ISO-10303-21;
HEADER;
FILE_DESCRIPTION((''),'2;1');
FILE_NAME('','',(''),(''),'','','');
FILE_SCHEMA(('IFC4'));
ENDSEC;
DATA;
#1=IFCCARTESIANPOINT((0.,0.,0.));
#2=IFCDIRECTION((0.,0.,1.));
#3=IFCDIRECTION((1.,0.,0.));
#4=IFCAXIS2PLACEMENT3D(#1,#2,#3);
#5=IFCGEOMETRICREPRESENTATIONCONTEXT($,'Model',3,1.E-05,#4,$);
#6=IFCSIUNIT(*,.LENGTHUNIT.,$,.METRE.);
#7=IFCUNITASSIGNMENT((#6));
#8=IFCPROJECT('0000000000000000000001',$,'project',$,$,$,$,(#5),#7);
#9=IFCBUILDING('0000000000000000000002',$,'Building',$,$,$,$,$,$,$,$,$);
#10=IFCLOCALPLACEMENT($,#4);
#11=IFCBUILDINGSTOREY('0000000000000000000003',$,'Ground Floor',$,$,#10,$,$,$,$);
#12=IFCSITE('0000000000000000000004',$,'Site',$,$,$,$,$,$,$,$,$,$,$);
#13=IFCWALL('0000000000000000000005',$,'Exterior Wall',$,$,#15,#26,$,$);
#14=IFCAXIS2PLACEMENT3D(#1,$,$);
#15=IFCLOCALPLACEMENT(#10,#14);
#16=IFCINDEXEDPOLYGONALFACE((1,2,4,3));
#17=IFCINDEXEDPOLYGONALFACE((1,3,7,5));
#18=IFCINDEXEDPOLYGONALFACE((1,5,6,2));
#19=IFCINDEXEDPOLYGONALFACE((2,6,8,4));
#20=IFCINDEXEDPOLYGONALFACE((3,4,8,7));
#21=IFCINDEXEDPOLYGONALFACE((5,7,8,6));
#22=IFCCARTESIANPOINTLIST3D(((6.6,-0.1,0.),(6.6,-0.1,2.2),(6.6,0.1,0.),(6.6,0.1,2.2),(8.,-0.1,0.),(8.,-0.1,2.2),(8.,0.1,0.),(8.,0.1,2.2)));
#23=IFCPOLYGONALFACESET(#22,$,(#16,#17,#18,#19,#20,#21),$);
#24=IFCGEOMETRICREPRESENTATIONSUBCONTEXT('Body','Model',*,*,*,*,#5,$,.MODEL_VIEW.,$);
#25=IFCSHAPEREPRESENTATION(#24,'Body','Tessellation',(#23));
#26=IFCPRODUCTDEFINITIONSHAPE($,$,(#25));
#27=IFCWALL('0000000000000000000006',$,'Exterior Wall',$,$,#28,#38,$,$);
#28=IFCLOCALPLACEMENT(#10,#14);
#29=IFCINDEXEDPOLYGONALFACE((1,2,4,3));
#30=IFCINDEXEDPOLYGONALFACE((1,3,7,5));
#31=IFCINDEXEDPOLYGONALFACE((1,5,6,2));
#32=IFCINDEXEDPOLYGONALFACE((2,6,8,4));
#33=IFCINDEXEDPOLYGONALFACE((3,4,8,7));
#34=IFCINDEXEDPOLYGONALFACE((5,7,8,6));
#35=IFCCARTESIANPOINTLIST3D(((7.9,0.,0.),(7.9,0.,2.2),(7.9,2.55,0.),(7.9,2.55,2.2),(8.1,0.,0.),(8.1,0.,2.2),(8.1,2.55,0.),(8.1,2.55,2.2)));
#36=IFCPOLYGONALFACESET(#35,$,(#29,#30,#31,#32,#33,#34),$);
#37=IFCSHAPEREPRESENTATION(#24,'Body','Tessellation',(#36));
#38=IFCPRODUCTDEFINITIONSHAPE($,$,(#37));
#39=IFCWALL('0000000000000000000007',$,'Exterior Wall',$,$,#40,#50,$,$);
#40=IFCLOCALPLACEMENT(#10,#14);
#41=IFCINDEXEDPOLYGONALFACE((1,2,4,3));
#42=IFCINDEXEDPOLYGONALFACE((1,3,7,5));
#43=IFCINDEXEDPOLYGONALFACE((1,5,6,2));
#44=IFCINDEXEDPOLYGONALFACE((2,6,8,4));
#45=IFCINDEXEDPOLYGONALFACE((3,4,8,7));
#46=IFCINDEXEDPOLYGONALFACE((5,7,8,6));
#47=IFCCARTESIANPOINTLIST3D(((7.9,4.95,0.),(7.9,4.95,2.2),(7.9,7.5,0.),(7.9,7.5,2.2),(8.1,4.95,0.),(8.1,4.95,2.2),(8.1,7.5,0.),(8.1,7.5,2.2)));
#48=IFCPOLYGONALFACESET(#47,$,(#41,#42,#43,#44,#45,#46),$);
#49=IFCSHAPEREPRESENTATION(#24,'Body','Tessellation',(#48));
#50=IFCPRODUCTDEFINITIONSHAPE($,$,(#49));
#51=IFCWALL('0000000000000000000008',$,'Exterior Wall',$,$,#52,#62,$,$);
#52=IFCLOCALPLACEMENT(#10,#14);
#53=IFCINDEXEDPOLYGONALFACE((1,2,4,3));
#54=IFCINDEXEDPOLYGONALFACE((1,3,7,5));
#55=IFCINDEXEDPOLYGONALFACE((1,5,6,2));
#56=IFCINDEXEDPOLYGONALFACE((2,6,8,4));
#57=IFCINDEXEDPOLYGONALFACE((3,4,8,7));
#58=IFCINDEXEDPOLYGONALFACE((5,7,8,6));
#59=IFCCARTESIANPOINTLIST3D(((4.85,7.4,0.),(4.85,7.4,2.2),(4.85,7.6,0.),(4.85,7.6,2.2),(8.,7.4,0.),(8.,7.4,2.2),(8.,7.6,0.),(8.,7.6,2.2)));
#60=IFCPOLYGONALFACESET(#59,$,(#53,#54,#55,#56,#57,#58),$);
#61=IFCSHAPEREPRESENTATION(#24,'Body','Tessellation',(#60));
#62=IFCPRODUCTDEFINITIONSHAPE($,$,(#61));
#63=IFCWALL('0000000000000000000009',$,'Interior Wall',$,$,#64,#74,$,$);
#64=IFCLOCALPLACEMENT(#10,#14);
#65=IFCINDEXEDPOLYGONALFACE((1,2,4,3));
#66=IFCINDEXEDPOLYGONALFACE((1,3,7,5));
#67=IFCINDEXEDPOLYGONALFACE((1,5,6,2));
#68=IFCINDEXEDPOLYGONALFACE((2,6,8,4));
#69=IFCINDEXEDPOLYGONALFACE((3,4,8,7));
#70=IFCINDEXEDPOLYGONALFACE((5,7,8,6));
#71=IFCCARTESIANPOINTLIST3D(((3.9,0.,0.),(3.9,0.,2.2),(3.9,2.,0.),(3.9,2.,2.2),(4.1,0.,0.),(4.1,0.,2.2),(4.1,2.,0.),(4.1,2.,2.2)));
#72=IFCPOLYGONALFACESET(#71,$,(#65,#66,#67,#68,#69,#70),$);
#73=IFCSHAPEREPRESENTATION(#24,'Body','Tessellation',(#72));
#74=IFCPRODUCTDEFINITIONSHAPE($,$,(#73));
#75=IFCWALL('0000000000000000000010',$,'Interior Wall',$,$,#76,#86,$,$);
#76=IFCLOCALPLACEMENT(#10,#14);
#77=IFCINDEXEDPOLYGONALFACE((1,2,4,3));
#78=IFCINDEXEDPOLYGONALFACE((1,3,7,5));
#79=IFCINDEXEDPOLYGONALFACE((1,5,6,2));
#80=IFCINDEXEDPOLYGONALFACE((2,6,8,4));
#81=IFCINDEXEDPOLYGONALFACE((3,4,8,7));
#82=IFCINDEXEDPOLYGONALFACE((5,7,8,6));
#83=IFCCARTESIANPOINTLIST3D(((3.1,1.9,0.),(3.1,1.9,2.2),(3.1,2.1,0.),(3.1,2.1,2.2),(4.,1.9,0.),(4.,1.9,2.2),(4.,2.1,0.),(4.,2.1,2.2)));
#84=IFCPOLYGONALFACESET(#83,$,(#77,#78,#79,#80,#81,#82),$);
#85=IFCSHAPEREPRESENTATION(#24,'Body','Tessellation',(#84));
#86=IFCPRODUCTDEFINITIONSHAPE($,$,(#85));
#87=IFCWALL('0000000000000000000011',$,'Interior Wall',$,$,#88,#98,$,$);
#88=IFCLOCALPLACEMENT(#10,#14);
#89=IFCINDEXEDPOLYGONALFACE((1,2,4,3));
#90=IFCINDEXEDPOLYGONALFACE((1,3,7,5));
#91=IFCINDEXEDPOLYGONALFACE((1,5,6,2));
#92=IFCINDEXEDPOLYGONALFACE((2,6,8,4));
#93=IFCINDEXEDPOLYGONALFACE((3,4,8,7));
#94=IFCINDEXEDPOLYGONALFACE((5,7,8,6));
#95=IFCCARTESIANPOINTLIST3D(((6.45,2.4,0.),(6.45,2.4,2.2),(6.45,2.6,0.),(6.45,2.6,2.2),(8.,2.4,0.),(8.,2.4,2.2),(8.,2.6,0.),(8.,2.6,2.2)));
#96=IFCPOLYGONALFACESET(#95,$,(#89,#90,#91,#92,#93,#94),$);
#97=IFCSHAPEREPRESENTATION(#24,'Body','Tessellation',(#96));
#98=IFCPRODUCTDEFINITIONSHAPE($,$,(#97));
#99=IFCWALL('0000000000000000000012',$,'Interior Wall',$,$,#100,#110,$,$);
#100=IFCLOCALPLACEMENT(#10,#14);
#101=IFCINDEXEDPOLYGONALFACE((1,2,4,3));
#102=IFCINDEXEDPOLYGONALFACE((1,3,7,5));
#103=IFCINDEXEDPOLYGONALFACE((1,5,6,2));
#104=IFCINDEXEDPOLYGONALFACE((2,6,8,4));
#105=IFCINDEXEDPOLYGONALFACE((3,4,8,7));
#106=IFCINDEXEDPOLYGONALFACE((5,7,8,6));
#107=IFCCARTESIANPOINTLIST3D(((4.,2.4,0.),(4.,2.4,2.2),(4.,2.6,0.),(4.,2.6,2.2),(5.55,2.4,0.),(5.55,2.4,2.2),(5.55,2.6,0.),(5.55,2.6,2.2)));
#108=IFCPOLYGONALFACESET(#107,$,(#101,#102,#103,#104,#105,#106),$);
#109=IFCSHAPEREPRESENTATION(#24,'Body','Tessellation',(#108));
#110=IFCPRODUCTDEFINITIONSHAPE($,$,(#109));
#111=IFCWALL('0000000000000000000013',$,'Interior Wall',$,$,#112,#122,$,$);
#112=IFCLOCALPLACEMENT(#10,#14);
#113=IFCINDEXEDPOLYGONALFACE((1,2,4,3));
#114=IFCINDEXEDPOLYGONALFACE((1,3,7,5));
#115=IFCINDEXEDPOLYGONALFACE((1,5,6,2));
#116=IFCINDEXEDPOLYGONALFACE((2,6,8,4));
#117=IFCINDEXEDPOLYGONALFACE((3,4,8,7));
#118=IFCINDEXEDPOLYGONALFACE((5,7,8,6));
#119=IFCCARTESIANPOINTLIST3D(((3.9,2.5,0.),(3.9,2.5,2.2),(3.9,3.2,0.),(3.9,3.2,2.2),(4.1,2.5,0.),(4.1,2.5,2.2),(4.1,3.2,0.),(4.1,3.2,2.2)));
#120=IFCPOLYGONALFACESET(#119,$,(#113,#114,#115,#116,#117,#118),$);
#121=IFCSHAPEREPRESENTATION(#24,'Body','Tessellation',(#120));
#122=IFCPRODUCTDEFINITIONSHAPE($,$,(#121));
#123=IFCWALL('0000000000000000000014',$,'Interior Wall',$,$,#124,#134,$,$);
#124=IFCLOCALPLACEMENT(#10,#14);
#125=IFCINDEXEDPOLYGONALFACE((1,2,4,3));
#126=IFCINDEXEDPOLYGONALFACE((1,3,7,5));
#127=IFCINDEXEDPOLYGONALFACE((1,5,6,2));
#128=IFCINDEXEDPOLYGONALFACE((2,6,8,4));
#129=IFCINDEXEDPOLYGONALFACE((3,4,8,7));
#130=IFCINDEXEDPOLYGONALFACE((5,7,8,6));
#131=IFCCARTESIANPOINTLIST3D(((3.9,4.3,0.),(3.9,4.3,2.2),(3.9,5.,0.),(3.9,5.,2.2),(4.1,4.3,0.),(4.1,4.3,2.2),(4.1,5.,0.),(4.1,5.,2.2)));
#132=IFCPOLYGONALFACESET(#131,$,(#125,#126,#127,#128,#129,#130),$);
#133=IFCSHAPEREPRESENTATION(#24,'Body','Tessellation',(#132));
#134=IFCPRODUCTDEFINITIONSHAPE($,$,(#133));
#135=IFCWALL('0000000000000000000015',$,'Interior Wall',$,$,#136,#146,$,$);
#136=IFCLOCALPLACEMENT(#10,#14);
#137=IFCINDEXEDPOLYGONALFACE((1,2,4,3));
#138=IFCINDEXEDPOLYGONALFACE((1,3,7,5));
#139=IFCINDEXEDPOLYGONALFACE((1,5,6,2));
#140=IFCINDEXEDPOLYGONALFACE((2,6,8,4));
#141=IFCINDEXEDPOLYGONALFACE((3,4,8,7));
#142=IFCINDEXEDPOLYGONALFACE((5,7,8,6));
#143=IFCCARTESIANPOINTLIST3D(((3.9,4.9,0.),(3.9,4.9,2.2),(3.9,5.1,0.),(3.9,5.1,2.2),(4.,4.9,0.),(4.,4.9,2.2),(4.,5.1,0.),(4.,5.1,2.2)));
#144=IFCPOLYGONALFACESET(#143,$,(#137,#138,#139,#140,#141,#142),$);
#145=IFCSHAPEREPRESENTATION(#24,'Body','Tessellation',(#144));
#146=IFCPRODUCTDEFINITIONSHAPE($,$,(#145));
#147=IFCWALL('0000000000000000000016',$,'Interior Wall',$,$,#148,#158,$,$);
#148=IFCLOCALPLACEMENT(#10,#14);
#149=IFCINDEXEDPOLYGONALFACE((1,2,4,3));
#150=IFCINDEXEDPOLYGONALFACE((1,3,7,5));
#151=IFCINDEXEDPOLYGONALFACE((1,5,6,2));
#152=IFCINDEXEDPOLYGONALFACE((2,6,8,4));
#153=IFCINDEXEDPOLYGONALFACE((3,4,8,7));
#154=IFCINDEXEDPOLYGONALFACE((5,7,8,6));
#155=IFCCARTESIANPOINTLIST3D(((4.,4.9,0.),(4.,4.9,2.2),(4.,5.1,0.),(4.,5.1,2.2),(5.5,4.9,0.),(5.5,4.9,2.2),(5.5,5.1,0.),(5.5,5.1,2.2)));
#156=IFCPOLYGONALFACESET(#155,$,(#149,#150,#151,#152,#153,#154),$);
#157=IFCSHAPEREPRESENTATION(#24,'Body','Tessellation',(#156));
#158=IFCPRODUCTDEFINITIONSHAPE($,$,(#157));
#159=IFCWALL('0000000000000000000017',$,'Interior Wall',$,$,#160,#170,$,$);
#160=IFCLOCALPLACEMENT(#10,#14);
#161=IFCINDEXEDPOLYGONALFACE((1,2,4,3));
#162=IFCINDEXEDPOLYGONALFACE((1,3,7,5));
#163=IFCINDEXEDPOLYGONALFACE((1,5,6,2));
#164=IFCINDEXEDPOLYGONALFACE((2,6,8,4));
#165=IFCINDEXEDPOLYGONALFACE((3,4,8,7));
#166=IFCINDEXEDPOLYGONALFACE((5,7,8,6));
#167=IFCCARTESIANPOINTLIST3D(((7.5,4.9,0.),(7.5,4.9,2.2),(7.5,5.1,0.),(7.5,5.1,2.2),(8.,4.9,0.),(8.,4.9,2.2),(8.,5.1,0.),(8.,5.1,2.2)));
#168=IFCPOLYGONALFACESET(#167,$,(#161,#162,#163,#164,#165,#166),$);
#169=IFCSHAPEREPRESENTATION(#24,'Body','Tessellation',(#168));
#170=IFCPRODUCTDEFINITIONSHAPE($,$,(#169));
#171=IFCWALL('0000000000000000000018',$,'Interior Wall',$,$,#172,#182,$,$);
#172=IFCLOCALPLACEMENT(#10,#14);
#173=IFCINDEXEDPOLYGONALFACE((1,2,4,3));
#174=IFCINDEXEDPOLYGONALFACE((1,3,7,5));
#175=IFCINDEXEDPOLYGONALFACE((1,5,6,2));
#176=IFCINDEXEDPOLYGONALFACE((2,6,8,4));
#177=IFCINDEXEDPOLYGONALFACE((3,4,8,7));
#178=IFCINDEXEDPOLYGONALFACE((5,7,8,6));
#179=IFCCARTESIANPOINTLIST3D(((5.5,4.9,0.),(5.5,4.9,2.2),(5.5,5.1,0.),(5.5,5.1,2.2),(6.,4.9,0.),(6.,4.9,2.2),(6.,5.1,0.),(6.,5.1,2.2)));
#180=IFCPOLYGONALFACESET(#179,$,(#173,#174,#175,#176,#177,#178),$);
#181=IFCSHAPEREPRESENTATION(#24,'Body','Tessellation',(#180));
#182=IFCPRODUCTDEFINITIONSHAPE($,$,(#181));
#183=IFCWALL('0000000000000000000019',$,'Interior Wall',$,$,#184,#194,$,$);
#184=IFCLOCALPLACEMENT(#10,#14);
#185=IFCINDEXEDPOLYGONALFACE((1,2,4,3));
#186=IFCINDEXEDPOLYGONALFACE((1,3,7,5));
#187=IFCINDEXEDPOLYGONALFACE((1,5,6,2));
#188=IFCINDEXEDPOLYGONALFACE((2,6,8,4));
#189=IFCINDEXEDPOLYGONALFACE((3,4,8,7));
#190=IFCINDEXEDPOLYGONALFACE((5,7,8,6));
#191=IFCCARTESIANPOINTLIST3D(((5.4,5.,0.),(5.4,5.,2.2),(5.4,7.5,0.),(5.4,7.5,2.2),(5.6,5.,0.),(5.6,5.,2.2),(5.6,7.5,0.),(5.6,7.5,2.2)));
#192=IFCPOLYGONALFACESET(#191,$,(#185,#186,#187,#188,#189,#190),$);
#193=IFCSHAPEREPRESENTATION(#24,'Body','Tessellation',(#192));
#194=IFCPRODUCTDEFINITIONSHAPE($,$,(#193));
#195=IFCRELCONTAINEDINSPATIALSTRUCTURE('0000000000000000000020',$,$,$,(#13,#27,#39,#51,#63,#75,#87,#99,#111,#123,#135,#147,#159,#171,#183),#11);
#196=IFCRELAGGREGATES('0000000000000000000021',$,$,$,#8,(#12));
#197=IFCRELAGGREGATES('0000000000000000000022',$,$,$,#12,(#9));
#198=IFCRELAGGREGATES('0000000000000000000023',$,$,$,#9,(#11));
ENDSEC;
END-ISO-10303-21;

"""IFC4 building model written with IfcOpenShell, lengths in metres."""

from ifc_helpers import new_model, si_unit, frame, origin_with_axes, place, context, subcontext, project, spatial, indexed_curve, outline, extrude, element, save


model = new_model("IFC4")

# Units and contexts
model_context = context("Model", 3, precision=1e-05, world=origin_with_axes())
body_context = subcontext(model_context, "Body", "Model", "MODEL_VIEW")
ifc_project = project(units=[si_unit("LENGTHUNIT", "METRE")], contexts=[model_context])

# Site, building, storey
site = spatial("IfcSite", under=ifc_project, Name="Site")
building = spatial("IfcBuilding", under=site, Name="Building")
storey_placement = place(None, origin_with_axes())
storey = spatial("IfcBuildingStorey", under=building, at=storey_placement, Name="Ground Floor")

# Walls
wall_1_placement = place(storey_placement, frame((6.6, 0.0, 0.0), z_axis=(0.0, 0.0, 1.0), x_axis=(1.0, 0.0, 0.0)))
element("IfcWall", 1, at=wall_1_placement, inside=storey, Name="Exterior Wall", context=body_context, shape_type="SweptSolid", body=[
    extrude(outline(indexed_curve([(0.0, 0.0), (0.0, 0.2), (1.4, 0.2), (1.4, 0.0), (0.0, 0.0)], self_intersect=False)), frame((0.0, -0.1, 0.0), z_axis=(0.0, 0.0, 1.0), x_axis=(1.0, 0.0, 0.0)), (0.0, 0.0, 1.0), 2.2),
])
for number, where, z_axis, x_axis, name in (
    (2, (8.0, 0.0, 0.0), (0.0, 0.0, 1.0), (0.0, 1.0, 0.0), "Exterior Wall"),
    (3, (8.0, 4.95, 0.0), (0.0, 0.0, 1.0), (0.0, 1.0, 0.0), "Exterior Wall"),
):
    element("IfcWall", number, at=place(storey_placement, frame(where, z_axis=z_axis, x_axis=x_axis)), inside=storey, Name=name, context=body_context, shape_type="SweptSolid", body=[
        extrude(outline(indexed_curve([(0.0, 0.0), (0.0, 0.2), (2.55, 0.2), (2.55, 0.0), (0.0, 0.0)], self_intersect=False)), frame((0.0, -0.1, 0.0), z_axis=(0.0, 0.0, 1.0), x_axis=(1.0, 0.0, 0.0)), (0.0, 0.0, 1.0), 2.2),
    ])
wall_2_placement = place(storey_placement, frame((8.0, 7.5, 0.0), z_axis=(0.0, 0.0, 1.0), x_axis=(-1.0, 0.0, 0.0)))
element("IfcWall", 4, at=wall_2_placement, inside=storey, Name="Exterior Wall", context=body_context, shape_type="SweptSolid", body=[
    extrude(outline(indexed_curve([(0.0, 0.0), (0.0, 0.2), (3.15, 0.2), (3.15, 0.0), (0.0, 0.0)], self_intersect=False)), frame((0.0, -0.1, 0.0), z_axis=(0.0, 0.0, 1.0), x_axis=(1.0, 0.0, 0.0)), (0.0, 0.0, 1.0), 2.2),
])
wall_3_placement = place(storey_placement, frame((4.0, 0.0, 0.0), z_axis=(0.0, 0.0, 1.0), x_axis=(0.0, 1.0, 0.0)))
element("IfcWall", 5, at=wall_3_placement, inside=storey, Name="Interior Wall", context=body_context, shape_type="SweptSolid", body=[
    extrude(outline(indexed_curve([(0.0, 0.0), (0.0, 0.2), (2.0, 0.2), (2.0, 0.0), (0.0, 0.0)], self_intersect=False)), frame((0.0, -0.1, 0.0), z_axis=(0.0, 0.0, 1.0), x_axis=(1.0, 0.0, 0.0)), (0.0, 0.0, 1.0), 2.2),
])
wall_4_placement = place(storey_placement, frame((4.0, 2.0, 0.0), z_axis=(0.0, 0.0, 1.0), x_axis=(-1.0, 0.0, 0.0)))
element("IfcWall", 6, at=wall_4_placement, inside=storey, Name="Interior Wall", context=body_context, shape_type="SweptSolid", body=[
    extrude(outline(indexed_curve([(0.0, 0.0), (0.0, 0.2), (0.9, 0.2), (0.9, 0.0), (0.0, 0.0)], self_intersect=False)), frame((0.0, -0.1, 0.0), z_axis=(0.0, 0.0, 1.0), x_axis=(1.0, 0.0, 0.0)), (0.0, 0.0, 1.0), 2.2),
])
for number, where, z_axis, x_axis, name in (
    (7, (8.0, 2.5, 0.0), (0.0, 0.0, 1.0), (-1.0, 0.0, 0.0), "Interior Wall"),
    (8, (5.55, 2.5, 0.0), (0.0, 0.0, 1.0), (-1.0, 0.0, 0.0), "Interior Wall"),
):
    element("IfcWall", number, at=place(storey_placement, frame(where, z_axis=z_axis, x_axis=x_axis)), inside=storey, Name=name, context=body_context, shape_type="SweptSolid", body=[
        extrude(outline(indexed_curve([(0.0, 0.0), (0.0, 0.2), (1.55, 0.2), (1.55, 0.0), (0.0, 0.0)], self_intersect=False)), frame((0.0, -0.1, 0.0), z_axis=(0.0, 0.0, 1.0), x_axis=(1.0, 0.0, 0.0)), (0.0, 0.0, 1.0), 2.2),
    ])
for number, where, z_axis, x_axis, name in (
    (9, (4.0, 2.5, 0.0), (0.0, 0.0, 1.0), (0.0, 1.0, 0.0), "Interior Wall"),
    (10, (4.0, 4.3, 0.0), (0.0, 0.0, 1.0), (0.0, 1.0, 0.0), "Interior Wall"),
):
    element("IfcWall", number, at=place(storey_placement, frame(where, z_axis=z_axis, x_axis=x_axis)), inside=storey, Name=name, context=body_context, shape_type="SweptSolid", body=[
        extrude(outline(indexed_curve([(0.0, 0.0), (0.0, 0.2), (0.7, 0.2), (0.7, 0.0), (0.0, 0.0)], self_intersect=False)), frame((0.0, -0.1, 0.0), z_axis=(0.0, 0.0, 1.0), x_axis=(1.0, 0.0, 0.0)), (0.0, 0.0, 1.0), 2.2),
    ])
wall_5_placement = place(storey_placement, frame((4.0, 5.0, 0.0), z_axis=(0.0, 0.0, 1.0), x_axis=(-1.0, 0.0, 0.0)))
element("IfcWall", 11, at=wall_5_placement, inside=storey, Name="Interior Wall", context=body_context, shape_type="SweptSolid", body=[
    extrude(outline(indexed_curve([(0.0, 0.0), (0.0, 0.2), (0.1, 0.2), (0.1, 0.0), (0.0, 0.0)], self_intersect=False)), frame((0.0, -0.1, 0.0), z_axis=(0.0, 0.0, 1.0), x_axis=(1.0, 0.0, 0.0)), (0.0, 0.0, 1.0), 2.2),
])
wall_6_placement = place(storey_placement, frame((5.5, 5.0, 0.0), z_axis=(0.0, 0.0, 1.0), x_axis=(-1.0, 0.0, 0.0)))
element("IfcWall", 12, at=wall_6_placement, inside=storey, Name="Interior Wall", context=body_context, shape_type="SweptSolid", body=[
    extrude(outline(indexed_curve([(0.0, 0.0), (0.0, 0.2), (1.5, 0.2), (1.5, 0.0), (0.0, 0.0)], self_intersect=False)), frame((0.0, -0.1, 0.0), z_axis=(0.0, 0.0, 1.0), x_axis=(1.0, 0.0, 0.0)), (0.0, 0.0, 1.0), 2.2),
])
for number, where, z_axis, x_axis, name in (
    (13, (8.0, 5.0, 0.0), (0.0, 0.0, 1.0), (-1.0, 0.0, 0.0), "Interior Wall"),
    (14, (6.0, 5.0, 0.0), (0.0, 0.0, 1.0), (-1.0, 0.0, 0.0), "Interior Wall"),
):
    element("IfcWall", number, at=place(storey_placement, frame(where, z_axis=z_axis, x_axis=x_axis)), inside=storey, Name=name, context=body_context, shape_type="SweptSolid", body=[
        extrude(outline(indexed_curve([(0.0, 0.0), (0.0, 0.2), (0.5, 0.2), (0.5, 0.0), (0.0, 0.0)], self_intersect=False)), frame((0.0, -0.1, 0.0), z_axis=(0.0, 0.0, 1.0), x_axis=(1.0, 0.0, 0.0)), (0.0, 0.0, 1.0), 2.2),
    ])
wall_7_placement = place(storey_placement, frame((5.5, 5.0, 0.0), z_axis=(0.0, 0.0, 1.0), x_axis=(0.0, 1.0, 0.0)))
element("IfcWall", 15, at=wall_7_placement, inside=storey, Name="Interior Wall", context=body_context, shape_type="SweptSolid", body=[
    extrude(outline(indexed_curve([(0.0, 0.0), (0.0, 0.2), (2.5, 0.2), (2.5, 0.0), (0.0, 0.0)], self_intersect=False)), frame((0.0, -0.1, 0.0), z_axis=(0.0, 0.0, 1.0), x_axis=(1.0, 0.0, 0.0)), (0.0, 0.0, 1.0), 2.2),
])

save(model, "model.ifc")
